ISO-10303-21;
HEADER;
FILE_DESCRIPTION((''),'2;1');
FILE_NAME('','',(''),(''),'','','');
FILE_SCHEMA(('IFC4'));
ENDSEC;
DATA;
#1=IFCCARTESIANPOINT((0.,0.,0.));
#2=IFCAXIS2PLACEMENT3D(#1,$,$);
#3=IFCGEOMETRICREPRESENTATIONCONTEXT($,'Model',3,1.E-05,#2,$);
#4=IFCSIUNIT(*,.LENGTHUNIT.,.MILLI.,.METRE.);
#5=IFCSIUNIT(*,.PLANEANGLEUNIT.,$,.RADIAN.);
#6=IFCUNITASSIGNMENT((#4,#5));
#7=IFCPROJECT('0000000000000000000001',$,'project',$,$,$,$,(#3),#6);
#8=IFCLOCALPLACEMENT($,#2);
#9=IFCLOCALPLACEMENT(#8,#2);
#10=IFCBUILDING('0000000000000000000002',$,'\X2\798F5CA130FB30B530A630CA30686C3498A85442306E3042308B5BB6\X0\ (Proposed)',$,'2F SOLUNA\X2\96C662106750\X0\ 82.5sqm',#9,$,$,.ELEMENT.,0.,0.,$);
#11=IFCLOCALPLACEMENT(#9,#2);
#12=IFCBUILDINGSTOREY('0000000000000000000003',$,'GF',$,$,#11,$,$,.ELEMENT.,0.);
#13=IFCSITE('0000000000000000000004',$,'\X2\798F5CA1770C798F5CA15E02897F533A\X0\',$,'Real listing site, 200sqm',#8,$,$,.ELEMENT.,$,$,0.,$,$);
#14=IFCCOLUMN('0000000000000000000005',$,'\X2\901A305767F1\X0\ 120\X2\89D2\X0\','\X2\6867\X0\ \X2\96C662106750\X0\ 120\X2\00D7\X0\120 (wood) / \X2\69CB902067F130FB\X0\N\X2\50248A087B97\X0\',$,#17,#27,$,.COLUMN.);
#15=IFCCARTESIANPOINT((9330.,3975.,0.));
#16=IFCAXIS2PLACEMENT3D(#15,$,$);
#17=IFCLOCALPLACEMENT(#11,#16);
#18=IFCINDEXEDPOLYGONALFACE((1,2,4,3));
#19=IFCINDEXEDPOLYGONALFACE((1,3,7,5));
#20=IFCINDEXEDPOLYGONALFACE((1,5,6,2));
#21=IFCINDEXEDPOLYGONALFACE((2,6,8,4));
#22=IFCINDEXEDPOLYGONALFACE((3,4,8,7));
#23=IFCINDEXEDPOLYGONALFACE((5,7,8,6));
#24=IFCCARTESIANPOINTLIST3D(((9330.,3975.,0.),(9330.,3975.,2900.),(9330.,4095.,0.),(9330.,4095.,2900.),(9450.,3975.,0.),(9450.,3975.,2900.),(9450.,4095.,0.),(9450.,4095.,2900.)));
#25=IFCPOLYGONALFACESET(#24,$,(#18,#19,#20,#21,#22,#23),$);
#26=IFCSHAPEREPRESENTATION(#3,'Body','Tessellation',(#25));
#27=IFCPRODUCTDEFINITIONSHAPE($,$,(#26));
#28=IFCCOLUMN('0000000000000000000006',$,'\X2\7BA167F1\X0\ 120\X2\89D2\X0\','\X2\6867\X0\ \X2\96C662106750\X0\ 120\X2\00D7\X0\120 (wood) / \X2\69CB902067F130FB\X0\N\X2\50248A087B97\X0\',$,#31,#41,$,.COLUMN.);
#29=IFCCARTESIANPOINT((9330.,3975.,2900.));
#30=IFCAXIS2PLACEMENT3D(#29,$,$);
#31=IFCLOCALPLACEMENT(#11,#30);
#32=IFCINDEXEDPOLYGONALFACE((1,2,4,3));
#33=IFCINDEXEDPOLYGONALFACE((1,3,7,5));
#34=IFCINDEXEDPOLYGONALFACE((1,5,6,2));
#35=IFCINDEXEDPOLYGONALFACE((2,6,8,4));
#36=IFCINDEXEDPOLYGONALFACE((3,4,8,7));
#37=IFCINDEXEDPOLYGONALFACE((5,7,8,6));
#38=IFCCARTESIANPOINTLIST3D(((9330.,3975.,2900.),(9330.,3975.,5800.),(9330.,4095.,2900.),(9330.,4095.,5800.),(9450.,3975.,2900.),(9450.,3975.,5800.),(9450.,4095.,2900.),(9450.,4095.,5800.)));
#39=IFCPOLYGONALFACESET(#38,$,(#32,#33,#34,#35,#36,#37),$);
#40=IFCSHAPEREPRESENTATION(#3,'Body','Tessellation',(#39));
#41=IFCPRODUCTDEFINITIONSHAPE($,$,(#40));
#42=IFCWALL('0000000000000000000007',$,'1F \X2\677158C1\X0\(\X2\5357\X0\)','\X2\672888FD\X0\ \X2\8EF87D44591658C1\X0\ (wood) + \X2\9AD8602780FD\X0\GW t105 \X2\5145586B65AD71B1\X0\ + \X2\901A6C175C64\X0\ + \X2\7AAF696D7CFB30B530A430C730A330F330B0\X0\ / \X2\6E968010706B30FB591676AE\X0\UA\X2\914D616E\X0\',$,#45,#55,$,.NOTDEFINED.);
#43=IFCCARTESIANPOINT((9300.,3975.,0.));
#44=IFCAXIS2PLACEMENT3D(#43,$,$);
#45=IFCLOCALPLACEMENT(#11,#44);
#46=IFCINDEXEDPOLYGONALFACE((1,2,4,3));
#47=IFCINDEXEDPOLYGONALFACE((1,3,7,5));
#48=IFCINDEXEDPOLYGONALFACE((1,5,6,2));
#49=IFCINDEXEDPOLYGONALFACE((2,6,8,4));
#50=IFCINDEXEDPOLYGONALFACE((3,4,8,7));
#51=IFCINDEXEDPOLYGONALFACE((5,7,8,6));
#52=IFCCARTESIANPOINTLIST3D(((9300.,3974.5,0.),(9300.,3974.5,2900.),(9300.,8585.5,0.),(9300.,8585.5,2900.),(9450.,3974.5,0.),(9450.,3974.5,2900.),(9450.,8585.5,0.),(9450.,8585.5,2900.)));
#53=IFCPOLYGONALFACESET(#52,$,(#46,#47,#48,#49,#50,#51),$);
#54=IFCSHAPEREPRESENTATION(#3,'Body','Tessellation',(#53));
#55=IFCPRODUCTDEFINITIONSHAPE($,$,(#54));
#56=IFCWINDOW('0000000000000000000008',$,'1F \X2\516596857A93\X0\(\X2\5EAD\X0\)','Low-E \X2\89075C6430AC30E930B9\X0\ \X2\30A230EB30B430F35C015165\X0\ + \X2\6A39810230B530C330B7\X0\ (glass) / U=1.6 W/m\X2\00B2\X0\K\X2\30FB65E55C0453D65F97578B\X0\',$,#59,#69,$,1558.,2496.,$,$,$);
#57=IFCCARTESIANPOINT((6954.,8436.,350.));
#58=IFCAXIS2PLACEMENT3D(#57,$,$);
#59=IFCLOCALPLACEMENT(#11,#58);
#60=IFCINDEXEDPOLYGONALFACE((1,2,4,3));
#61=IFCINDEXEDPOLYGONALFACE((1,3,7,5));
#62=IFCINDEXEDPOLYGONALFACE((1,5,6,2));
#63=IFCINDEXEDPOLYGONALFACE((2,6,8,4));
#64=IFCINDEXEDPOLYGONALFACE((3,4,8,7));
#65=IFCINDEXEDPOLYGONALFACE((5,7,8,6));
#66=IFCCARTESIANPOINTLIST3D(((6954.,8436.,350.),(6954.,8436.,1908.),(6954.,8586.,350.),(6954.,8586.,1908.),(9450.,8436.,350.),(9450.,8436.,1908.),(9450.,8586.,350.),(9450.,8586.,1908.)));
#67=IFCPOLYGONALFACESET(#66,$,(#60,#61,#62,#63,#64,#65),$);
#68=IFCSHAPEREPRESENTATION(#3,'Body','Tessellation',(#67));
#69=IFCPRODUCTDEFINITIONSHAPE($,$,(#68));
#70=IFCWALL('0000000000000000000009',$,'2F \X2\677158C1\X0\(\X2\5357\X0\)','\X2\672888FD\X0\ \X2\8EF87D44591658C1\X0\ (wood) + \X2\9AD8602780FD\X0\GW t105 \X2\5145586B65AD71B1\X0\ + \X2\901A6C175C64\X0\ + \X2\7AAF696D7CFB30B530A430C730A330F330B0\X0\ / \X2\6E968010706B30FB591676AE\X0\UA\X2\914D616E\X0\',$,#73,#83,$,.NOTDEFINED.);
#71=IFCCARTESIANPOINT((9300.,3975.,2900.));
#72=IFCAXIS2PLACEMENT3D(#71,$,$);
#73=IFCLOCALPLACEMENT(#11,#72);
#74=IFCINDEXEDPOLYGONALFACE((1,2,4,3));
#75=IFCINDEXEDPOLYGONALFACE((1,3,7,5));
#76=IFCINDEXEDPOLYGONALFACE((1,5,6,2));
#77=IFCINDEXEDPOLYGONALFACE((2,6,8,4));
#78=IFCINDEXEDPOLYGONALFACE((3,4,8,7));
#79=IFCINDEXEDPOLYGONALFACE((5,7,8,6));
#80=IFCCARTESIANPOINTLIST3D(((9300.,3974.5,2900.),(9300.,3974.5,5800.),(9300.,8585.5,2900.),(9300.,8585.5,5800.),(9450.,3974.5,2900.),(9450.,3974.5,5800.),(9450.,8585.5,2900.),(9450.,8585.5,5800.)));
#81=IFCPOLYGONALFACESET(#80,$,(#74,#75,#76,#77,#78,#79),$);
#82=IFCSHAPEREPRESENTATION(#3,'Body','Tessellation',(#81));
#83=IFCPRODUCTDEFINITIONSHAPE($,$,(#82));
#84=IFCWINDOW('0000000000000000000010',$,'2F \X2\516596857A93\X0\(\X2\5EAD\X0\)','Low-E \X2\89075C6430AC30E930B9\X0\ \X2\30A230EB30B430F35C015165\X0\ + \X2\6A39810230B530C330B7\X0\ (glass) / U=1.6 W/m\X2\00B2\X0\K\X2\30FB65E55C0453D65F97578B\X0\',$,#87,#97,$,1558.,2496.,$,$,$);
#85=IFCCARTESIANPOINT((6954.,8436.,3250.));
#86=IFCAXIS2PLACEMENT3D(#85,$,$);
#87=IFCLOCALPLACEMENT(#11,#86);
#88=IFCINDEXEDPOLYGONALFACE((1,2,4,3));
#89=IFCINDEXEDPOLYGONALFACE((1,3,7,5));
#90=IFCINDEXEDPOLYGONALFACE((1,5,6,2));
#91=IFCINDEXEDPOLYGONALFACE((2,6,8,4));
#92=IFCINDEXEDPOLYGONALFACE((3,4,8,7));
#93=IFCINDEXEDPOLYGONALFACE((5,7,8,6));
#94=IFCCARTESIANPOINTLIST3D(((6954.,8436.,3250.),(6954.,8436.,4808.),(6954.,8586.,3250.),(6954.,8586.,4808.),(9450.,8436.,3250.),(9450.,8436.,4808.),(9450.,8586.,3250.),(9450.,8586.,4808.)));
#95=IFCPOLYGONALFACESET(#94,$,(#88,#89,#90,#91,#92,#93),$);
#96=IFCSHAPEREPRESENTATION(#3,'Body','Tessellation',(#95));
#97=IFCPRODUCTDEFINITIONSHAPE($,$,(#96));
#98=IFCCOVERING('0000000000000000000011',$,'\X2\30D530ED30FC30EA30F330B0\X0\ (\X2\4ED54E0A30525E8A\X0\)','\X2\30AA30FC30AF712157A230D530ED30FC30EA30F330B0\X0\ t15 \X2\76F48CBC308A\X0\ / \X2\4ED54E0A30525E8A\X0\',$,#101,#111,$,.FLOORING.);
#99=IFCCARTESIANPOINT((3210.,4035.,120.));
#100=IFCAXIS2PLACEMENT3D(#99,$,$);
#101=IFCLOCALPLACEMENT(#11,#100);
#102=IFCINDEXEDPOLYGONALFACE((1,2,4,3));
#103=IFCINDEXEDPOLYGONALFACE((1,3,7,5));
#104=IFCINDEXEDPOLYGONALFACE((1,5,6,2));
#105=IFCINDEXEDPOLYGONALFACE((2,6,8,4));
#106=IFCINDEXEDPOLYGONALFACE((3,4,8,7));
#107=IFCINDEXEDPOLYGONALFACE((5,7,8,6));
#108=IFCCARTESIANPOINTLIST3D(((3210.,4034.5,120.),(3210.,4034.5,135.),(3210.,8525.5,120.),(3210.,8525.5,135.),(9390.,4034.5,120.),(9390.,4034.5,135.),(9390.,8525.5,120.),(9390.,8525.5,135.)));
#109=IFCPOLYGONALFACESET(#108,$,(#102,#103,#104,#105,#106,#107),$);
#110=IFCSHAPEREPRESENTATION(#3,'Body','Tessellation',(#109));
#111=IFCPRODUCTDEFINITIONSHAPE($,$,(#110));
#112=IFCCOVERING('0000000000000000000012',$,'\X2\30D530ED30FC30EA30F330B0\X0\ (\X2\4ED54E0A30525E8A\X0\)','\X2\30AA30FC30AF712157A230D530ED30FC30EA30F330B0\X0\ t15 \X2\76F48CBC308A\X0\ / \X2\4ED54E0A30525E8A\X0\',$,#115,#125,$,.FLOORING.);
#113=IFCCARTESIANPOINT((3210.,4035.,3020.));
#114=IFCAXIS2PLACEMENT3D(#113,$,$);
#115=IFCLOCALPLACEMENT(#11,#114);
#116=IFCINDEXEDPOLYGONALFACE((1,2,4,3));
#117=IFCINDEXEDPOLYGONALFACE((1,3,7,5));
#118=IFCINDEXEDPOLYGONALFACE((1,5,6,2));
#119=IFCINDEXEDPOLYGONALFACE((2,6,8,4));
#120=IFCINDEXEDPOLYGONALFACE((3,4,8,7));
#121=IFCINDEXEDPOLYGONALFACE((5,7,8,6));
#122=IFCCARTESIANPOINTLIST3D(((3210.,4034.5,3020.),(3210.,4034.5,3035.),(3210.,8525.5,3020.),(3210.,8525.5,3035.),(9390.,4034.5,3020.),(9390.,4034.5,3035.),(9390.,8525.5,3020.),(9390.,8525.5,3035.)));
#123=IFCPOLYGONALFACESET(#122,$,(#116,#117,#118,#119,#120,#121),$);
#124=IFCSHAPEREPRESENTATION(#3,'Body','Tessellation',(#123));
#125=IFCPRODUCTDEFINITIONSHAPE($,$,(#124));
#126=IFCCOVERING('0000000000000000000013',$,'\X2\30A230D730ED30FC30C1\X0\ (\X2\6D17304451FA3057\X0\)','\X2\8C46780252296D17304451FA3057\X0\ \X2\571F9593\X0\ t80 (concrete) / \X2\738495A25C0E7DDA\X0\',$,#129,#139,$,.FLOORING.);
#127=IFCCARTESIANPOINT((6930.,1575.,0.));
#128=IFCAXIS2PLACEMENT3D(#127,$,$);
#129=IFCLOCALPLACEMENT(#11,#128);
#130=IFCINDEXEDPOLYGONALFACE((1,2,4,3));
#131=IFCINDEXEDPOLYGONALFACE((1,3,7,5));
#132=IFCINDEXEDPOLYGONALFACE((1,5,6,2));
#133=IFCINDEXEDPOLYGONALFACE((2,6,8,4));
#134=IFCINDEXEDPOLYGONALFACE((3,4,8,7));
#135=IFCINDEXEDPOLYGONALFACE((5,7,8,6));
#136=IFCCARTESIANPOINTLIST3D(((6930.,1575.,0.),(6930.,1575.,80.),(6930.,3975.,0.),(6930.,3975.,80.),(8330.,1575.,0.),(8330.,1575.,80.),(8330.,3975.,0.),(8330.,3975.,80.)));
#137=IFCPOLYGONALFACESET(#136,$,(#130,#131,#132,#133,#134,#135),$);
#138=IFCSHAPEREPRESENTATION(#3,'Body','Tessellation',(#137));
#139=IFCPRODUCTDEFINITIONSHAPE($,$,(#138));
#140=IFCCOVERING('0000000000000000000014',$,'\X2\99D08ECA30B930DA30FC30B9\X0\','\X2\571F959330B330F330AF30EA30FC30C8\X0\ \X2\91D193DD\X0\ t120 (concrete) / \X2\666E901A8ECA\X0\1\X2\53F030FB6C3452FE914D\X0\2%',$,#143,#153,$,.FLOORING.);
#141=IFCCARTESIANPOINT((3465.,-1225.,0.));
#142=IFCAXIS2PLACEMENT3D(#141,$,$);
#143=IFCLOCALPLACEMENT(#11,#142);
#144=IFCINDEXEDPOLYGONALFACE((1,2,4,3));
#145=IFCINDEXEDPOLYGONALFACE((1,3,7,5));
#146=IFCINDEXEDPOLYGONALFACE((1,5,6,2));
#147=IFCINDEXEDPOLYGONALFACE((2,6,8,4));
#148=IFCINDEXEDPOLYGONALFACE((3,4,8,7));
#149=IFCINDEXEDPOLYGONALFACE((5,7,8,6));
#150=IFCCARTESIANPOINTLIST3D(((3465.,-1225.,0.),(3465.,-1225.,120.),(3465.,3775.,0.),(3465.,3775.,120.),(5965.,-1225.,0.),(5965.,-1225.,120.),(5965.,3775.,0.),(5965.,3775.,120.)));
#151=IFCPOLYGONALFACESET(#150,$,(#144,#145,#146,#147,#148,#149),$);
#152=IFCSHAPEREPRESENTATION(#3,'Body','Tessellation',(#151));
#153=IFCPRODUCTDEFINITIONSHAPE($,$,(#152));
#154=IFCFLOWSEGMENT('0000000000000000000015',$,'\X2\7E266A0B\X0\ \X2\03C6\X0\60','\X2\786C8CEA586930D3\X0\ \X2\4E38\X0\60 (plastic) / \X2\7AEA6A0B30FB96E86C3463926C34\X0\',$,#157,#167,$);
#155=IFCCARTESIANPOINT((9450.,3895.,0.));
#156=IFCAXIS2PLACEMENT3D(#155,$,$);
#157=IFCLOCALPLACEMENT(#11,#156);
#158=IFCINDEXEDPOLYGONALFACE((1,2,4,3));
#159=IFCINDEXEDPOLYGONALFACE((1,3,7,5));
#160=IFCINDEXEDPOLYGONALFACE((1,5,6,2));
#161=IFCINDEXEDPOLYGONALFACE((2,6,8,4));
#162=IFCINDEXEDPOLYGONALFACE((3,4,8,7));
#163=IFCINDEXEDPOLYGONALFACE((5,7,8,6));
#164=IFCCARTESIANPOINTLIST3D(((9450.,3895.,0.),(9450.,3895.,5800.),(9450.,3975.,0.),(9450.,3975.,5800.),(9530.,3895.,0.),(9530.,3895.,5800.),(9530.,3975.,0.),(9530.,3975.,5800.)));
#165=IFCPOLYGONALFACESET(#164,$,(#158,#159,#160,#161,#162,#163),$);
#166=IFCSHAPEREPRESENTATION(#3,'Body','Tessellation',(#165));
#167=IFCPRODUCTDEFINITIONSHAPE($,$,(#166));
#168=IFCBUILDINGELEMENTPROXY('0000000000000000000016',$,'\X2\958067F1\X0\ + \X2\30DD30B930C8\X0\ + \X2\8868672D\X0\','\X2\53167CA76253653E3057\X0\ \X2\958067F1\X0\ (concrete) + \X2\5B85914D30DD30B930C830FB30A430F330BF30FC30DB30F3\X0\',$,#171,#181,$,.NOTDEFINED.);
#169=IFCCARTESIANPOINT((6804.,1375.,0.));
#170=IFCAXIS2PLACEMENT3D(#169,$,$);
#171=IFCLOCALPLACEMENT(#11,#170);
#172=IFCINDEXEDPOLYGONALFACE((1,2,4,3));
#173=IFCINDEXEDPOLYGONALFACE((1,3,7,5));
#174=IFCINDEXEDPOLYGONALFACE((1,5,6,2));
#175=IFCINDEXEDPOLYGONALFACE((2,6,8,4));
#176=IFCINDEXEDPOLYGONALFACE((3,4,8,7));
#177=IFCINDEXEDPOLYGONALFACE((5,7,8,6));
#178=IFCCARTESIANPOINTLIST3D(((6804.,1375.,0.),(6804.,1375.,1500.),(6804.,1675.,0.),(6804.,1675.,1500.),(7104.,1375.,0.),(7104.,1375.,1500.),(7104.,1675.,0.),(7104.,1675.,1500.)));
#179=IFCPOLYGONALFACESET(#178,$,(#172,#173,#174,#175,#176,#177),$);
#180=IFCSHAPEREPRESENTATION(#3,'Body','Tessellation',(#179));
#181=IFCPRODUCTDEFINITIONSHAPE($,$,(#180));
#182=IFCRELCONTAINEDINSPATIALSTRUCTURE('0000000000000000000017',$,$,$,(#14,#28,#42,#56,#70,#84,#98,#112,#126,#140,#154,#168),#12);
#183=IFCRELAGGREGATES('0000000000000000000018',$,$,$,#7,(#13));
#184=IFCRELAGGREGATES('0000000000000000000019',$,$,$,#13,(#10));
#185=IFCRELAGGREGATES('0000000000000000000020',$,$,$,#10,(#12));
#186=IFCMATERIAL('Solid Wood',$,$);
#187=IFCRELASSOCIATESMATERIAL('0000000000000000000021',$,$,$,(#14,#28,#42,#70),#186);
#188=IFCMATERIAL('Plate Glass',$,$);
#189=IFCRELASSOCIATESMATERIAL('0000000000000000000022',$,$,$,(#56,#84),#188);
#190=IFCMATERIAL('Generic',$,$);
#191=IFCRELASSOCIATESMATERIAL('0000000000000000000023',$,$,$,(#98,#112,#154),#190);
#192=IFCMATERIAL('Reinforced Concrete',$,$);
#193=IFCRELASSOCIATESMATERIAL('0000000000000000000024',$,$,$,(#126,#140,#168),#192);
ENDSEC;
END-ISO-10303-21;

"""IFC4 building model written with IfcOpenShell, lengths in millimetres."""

from ifc_helpers import new_model, si_unit, frame, frame_2d, origin, place, context, project, spatial, rectangle, extrude, material, element, fill, save


model = new_model("IFC4")

# Units and contexts
model_context = context("Model", 3, precision=1e-05, world=origin())
ifc_project = project(units=[si_unit("LENGTHUNIT", "METRE", prefix="MILLI"), si_unit("PLANEANGLEUNIT", "RADIAN")], contexts=[model_context])

# Site, building, storey
site_placement = place(None, origin())
site = spatial("IfcSite", under=ifc_project, at=site_placement, Name="福岡県福岡市西区", ObjectType="Real listing site, 200sqm", CompositionType="ELEMENT", RefElevation=0.0)
building_placement = place(site_placement, origin())
building = spatial("IfcBuilding", under=site, at=building_placement, Name="福岡・サウナと水風呂のある家 (Proposed)", ObjectType="2F SOLUNA集成材 82.5sqm", CompositionType="ELEMENT", ElevationOfRefHeight=0.0, ElevationOfTerrain=0.0)
storey_placement = place(building_placement, origin())
storey = spatial("IfcBuildingStorey", under=building, at=storey_placement, Name="GF", CompositionType="ELEMENT", Elevation=0.0)

# Columns
ifc_material_1 = material(Name="Solid Wood")
column_1_placement = place(storey_placement, frame((9330.0, 3975.0, 0.0)))
element("IfcColumn", 1, at=column_1_placement, inside=storey, material=ifc_material_1, Name="通し柱 120角", Description="桧 集成材 120×120 (wood) / 構造柱・N値計算", PredefinedType="COLUMN", context=model_context, shape_type="SweptSolid", body=[
    extrude(rectangle(XDim=120.0, YDim=120.0, at=frame_2d((60.0, 60.0))), frame((9330.0, 3975.0, 0.0)), (0.0, 0.0, 1.0), 2900.0),
])
column_2_placement = place(storey_placement, frame((9330.0, 3975.0, 2900.0)))
element("IfcColumn", 2, at=column_2_placement, inside=storey, material=ifc_material_1, Name="管柱 120角", Description="桧 集成材 120×120 (wood) / 構造柱・N値計算", PredefinedType="COLUMN", context=model_context, shape_type="SweptSolid", body=[
    extrude(rectangle(XDim=120.0, YDim=120.0, at=frame_2d((60.0, 60.0))), frame((9330.0, 3975.0, 2900.0)), (0.0, 0.0, 1.0), 2900.0),
])

# Wall, opening, window
wall_1_placement = place(storey_placement, frame((9300.0, 3975.0, 0.0)))
wall_1 = element("IfcWall", 3, at=wall_1_placement, inside=storey, material=ifc_material_1, Name="1F 東壁(南)", Description="木製 軸組外壁 (wood) + 高性能GW t105 充填断熱 + 通気層 + 窯業系サイディング / 準耐火・外皮UA配慮", PredefinedType="NOTDEFINED", context=model_context, shape_type="SweptSolid", body=[
    extrude(rectangle(XDim=150.0, YDim=4611.0, at=frame_2d((75.0, 2305.0))), frame((9300.0, 3975.0, 0.0)), (0.0, 0.0, 1.0), 2900.0),
])
opening_1_placement = place(storey_placement, frame((6954.0, 8436.0, 350.0)))
opening_1 = element("IfcOpeningElement", 4, at=opening_1_placement, cuts=wall_1, PredefinedType="NOTDEFINED", context=model_context, shape_type="SweptSolid", body=[
    extrude(rectangle(XDim=2496.0, YDim=150.0, at=frame_2d((1248.0, 75.0))), frame((6954.0, 8436.0, 350.0)), (0.0, 0.0, 1.0), 1558.0),
])
ifc_material_2 = material(Name="Plate Glass")
window_1_placement = place(storey_placement, frame((6954.0, 8436.0, 350.0)))
window_1 = element("IfcWindow", 5, at=window_1_placement, inside=storey, material=ifc_material_2, Name="1F 入隅窓(庭)", Description="Low-E 複層ガラス アルゴン封入 + 樹脂サッシ (glass) / U=1.6 W/m²K・日射取得型", OverallHeight=1558.0, OverallWidth=2496.0, context=model_context, shape_type="SweptSolid", body=[
    extrude(rectangle(XDim=2496.0, YDim=150.0, at=frame_2d((1248.0, 75.0))), frame((6954.0, 8436.0, 350.0)), (0.0, 0.0, 1.0), 1558.0),
])
fill(opening_1, window_1)

# Wall, opening, window
wall_2_placement = place(storey_placement, frame((9300.0, 3975.0, 2900.0)))
wall_2 = element("IfcWall", 6, at=wall_2_placement, inside=storey, material=ifc_material_1, Name="2F 東壁(南)", Description="木製 軸組外壁 (wood) + 高性能GW t105 充填断熱 + 通気層 + 窯業系サイディング / 準耐火・外皮UA配慮", PredefinedType="NOTDEFINED", context=model_context, shape_type="SweptSolid", body=[
    extrude(rectangle(XDim=150.0, YDim=4611.0, at=frame_2d((75.0, 2305.0))), frame((9300.0, 3975.0, 2900.0)), (0.0, 0.0, 1.0), 2900.0),
])
opening_2_placement = place(storey_placement, frame((6954.0, 8436.0, 3250.0)))
opening_2 = element("IfcOpeningElement", 7, at=opening_2_placement, cuts=wall_2, PredefinedType="NOTDEFINED", context=model_context, shape_type="SweptSolid", body=[
    extrude(rectangle(XDim=2496.0, YDim=150.0, at=frame_2d((1248.0, 75.0))), frame((6954.0, 8436.0, 3250.0)), (0.0, 0.0, 1.0), 1558.0),
])
window_2_placement = place(storey_placement, frame((6954.0, 8436.0, 3250.0)))
window_2 = element("IfcWindow", 8, at=window_2_placement, inside=storey, material=ifc_material_2, Name="2F 入隅窓(庭)", Description="Low-E 複層ガラス アルゴン封入 + 樹脂サッシ (glass) / U=1.6 W/m²K・日射取得型", OverallHeight=1558.0, OverallWidth=2496.0, context=model_context, shape_type="SweptSolid", body=[
    extrude(rectangle(XDim=2496.0, YDim=150.0, at=frame_2d((1248.0, 75.0))), frame((6954.0, 8436.0, 3250.0)), (0.0, 0.0, 1.0), 1558.0),
])
fill(opening_2, window_2)

# Coverings
ifc_material_3 = material(Name="Generic")
covering_1_placement = place(storey_placement, frame((3210.0, 4035.0, 120.0)))
element("IfcCovering", 9, at=covering_1_placement, inside=storey, material=ifc_material_3, Name="フローリング (仕上げ床)", Description="オーク無垢フローリング t15 直貼り / 仕上げ床", PredefinedType="FLOORING", context=model_context, shape_type="SweptSolid", body=[
    extrude(rectangle(XDim=6180.0, YDim=4491.0, at=frame_2d((3090.0, 2245.0))), frame((3210.0, 4035.0, 120.0)), (0.0, 0.0, 1.0), 15.0),
])
covering_2_placement = place(storey_placement, frame((3210.0, 4035.0, 3020.0)))
element("IfcCovering", 10, at=covering_2_placement, inside=storey, material=ifc_material_3, Name="フローリング (仕上げ床)", Description="オーク無垢フローリング t15 直貼り / 仕上げ床", PredefinedType="FLOORING", context=model_context, shape_type="SweptSolid", body=[
    extrude(rectangle(XDim=6180.0, YDim=4491.0, at=frame_2d((3090.0, 2245.0))), frame((3210.0, 4035.0, 3020.0)), (0.0, 0.0, 1.0), 15.0),
])
ifc_material_4 = material(Name="Reinforced Concrete")
covering_3_placement = place(storey_placement, frame((6930.0, 1575.0, 0.0)))
element("IfcCovering", 11, at=covering_3_placement, inside=storey, material=ifc_material_4, Name="アプローチ (洗い出し)", Description="豆砂利洗い出し 土間 t80 (concrete) / 玄関導線", PredefinedType="FLOORING", context=model_context, shape_type="SweptSolid", body=[
    extrude(rectangle(XDim=1400.0, YDim=2400.0, at=frame_2d((700.0, 1200.0))), frame((6930.0, 1575.0, 0.0)), (0.0, 0.0, 1.0), 80.0),
])
covering_4_placement = place(storey_placement, frame((3465.0, -1225.0, 0.0)))
element("IfcCovering", 12, at=covering_4_placement, inside=storey, material=ifc_material_4, Name="駐車スペース", Description="土間コンクリート 金鏝 t120 (concrete) / 普通車1台・水勾配2%", PredefinedType="FLOORING", context=model_context, shape_type="SweptSolid", body=[
    extrude(rectangle(XDim=2500.0, YDim=5000.0, at=frame_2d((1250.0, 2500.0))), frame((3465.0, -1225.0, 0.0)), (0.0, 0.0, 1.0), 120.0),
])

# Flow segment
flow_segment_placement = place(storey_placement, frame((9450.0, 3895.0, 0.0)))
element("IfcFlowSegment", 13, at=flow_segment_placement, inside=storey, material=ifc_material_3, Name="縦樋 φ60", Description="硬質塩ビ 丸60 (plastic) / 竪樋・雨水排水", context=model_context, shape_type="SweptSolid", body=[
    extrude(rectangle(XDim=80.0, YDim=80.0, at=frame_2d((40.0, 40.0))), frame((9450.0, 3895.0, 0.0)), (0.0, 0.0, 1.0), 5800.0),
])

# Building element proxy
proxy_placement = place(storey_placement, frame((6804.0, 1375.0, 0.0)))
element("IfcBuildingElementProxy", 14, at=proxy_placement, inside=storey, material=ifc_material_4, Name="門柱 + ポスト + 表札", Description="化粧打放し 門柱 (concrete) + 宅配ポスト・インターホン", PredefinedType="NOTDEFINED", context=model_context, shape_type="SweptSolid", body=[
    extrude(rectangle(XDim=300.0, YDim=300.0, at=frame_2d((150.0, 150.0))), frame((6804.0, 1375.0, 0.0)), (0.0, 0.0, 1.0), 1500.0),
])

save(model, "model.ifc")
